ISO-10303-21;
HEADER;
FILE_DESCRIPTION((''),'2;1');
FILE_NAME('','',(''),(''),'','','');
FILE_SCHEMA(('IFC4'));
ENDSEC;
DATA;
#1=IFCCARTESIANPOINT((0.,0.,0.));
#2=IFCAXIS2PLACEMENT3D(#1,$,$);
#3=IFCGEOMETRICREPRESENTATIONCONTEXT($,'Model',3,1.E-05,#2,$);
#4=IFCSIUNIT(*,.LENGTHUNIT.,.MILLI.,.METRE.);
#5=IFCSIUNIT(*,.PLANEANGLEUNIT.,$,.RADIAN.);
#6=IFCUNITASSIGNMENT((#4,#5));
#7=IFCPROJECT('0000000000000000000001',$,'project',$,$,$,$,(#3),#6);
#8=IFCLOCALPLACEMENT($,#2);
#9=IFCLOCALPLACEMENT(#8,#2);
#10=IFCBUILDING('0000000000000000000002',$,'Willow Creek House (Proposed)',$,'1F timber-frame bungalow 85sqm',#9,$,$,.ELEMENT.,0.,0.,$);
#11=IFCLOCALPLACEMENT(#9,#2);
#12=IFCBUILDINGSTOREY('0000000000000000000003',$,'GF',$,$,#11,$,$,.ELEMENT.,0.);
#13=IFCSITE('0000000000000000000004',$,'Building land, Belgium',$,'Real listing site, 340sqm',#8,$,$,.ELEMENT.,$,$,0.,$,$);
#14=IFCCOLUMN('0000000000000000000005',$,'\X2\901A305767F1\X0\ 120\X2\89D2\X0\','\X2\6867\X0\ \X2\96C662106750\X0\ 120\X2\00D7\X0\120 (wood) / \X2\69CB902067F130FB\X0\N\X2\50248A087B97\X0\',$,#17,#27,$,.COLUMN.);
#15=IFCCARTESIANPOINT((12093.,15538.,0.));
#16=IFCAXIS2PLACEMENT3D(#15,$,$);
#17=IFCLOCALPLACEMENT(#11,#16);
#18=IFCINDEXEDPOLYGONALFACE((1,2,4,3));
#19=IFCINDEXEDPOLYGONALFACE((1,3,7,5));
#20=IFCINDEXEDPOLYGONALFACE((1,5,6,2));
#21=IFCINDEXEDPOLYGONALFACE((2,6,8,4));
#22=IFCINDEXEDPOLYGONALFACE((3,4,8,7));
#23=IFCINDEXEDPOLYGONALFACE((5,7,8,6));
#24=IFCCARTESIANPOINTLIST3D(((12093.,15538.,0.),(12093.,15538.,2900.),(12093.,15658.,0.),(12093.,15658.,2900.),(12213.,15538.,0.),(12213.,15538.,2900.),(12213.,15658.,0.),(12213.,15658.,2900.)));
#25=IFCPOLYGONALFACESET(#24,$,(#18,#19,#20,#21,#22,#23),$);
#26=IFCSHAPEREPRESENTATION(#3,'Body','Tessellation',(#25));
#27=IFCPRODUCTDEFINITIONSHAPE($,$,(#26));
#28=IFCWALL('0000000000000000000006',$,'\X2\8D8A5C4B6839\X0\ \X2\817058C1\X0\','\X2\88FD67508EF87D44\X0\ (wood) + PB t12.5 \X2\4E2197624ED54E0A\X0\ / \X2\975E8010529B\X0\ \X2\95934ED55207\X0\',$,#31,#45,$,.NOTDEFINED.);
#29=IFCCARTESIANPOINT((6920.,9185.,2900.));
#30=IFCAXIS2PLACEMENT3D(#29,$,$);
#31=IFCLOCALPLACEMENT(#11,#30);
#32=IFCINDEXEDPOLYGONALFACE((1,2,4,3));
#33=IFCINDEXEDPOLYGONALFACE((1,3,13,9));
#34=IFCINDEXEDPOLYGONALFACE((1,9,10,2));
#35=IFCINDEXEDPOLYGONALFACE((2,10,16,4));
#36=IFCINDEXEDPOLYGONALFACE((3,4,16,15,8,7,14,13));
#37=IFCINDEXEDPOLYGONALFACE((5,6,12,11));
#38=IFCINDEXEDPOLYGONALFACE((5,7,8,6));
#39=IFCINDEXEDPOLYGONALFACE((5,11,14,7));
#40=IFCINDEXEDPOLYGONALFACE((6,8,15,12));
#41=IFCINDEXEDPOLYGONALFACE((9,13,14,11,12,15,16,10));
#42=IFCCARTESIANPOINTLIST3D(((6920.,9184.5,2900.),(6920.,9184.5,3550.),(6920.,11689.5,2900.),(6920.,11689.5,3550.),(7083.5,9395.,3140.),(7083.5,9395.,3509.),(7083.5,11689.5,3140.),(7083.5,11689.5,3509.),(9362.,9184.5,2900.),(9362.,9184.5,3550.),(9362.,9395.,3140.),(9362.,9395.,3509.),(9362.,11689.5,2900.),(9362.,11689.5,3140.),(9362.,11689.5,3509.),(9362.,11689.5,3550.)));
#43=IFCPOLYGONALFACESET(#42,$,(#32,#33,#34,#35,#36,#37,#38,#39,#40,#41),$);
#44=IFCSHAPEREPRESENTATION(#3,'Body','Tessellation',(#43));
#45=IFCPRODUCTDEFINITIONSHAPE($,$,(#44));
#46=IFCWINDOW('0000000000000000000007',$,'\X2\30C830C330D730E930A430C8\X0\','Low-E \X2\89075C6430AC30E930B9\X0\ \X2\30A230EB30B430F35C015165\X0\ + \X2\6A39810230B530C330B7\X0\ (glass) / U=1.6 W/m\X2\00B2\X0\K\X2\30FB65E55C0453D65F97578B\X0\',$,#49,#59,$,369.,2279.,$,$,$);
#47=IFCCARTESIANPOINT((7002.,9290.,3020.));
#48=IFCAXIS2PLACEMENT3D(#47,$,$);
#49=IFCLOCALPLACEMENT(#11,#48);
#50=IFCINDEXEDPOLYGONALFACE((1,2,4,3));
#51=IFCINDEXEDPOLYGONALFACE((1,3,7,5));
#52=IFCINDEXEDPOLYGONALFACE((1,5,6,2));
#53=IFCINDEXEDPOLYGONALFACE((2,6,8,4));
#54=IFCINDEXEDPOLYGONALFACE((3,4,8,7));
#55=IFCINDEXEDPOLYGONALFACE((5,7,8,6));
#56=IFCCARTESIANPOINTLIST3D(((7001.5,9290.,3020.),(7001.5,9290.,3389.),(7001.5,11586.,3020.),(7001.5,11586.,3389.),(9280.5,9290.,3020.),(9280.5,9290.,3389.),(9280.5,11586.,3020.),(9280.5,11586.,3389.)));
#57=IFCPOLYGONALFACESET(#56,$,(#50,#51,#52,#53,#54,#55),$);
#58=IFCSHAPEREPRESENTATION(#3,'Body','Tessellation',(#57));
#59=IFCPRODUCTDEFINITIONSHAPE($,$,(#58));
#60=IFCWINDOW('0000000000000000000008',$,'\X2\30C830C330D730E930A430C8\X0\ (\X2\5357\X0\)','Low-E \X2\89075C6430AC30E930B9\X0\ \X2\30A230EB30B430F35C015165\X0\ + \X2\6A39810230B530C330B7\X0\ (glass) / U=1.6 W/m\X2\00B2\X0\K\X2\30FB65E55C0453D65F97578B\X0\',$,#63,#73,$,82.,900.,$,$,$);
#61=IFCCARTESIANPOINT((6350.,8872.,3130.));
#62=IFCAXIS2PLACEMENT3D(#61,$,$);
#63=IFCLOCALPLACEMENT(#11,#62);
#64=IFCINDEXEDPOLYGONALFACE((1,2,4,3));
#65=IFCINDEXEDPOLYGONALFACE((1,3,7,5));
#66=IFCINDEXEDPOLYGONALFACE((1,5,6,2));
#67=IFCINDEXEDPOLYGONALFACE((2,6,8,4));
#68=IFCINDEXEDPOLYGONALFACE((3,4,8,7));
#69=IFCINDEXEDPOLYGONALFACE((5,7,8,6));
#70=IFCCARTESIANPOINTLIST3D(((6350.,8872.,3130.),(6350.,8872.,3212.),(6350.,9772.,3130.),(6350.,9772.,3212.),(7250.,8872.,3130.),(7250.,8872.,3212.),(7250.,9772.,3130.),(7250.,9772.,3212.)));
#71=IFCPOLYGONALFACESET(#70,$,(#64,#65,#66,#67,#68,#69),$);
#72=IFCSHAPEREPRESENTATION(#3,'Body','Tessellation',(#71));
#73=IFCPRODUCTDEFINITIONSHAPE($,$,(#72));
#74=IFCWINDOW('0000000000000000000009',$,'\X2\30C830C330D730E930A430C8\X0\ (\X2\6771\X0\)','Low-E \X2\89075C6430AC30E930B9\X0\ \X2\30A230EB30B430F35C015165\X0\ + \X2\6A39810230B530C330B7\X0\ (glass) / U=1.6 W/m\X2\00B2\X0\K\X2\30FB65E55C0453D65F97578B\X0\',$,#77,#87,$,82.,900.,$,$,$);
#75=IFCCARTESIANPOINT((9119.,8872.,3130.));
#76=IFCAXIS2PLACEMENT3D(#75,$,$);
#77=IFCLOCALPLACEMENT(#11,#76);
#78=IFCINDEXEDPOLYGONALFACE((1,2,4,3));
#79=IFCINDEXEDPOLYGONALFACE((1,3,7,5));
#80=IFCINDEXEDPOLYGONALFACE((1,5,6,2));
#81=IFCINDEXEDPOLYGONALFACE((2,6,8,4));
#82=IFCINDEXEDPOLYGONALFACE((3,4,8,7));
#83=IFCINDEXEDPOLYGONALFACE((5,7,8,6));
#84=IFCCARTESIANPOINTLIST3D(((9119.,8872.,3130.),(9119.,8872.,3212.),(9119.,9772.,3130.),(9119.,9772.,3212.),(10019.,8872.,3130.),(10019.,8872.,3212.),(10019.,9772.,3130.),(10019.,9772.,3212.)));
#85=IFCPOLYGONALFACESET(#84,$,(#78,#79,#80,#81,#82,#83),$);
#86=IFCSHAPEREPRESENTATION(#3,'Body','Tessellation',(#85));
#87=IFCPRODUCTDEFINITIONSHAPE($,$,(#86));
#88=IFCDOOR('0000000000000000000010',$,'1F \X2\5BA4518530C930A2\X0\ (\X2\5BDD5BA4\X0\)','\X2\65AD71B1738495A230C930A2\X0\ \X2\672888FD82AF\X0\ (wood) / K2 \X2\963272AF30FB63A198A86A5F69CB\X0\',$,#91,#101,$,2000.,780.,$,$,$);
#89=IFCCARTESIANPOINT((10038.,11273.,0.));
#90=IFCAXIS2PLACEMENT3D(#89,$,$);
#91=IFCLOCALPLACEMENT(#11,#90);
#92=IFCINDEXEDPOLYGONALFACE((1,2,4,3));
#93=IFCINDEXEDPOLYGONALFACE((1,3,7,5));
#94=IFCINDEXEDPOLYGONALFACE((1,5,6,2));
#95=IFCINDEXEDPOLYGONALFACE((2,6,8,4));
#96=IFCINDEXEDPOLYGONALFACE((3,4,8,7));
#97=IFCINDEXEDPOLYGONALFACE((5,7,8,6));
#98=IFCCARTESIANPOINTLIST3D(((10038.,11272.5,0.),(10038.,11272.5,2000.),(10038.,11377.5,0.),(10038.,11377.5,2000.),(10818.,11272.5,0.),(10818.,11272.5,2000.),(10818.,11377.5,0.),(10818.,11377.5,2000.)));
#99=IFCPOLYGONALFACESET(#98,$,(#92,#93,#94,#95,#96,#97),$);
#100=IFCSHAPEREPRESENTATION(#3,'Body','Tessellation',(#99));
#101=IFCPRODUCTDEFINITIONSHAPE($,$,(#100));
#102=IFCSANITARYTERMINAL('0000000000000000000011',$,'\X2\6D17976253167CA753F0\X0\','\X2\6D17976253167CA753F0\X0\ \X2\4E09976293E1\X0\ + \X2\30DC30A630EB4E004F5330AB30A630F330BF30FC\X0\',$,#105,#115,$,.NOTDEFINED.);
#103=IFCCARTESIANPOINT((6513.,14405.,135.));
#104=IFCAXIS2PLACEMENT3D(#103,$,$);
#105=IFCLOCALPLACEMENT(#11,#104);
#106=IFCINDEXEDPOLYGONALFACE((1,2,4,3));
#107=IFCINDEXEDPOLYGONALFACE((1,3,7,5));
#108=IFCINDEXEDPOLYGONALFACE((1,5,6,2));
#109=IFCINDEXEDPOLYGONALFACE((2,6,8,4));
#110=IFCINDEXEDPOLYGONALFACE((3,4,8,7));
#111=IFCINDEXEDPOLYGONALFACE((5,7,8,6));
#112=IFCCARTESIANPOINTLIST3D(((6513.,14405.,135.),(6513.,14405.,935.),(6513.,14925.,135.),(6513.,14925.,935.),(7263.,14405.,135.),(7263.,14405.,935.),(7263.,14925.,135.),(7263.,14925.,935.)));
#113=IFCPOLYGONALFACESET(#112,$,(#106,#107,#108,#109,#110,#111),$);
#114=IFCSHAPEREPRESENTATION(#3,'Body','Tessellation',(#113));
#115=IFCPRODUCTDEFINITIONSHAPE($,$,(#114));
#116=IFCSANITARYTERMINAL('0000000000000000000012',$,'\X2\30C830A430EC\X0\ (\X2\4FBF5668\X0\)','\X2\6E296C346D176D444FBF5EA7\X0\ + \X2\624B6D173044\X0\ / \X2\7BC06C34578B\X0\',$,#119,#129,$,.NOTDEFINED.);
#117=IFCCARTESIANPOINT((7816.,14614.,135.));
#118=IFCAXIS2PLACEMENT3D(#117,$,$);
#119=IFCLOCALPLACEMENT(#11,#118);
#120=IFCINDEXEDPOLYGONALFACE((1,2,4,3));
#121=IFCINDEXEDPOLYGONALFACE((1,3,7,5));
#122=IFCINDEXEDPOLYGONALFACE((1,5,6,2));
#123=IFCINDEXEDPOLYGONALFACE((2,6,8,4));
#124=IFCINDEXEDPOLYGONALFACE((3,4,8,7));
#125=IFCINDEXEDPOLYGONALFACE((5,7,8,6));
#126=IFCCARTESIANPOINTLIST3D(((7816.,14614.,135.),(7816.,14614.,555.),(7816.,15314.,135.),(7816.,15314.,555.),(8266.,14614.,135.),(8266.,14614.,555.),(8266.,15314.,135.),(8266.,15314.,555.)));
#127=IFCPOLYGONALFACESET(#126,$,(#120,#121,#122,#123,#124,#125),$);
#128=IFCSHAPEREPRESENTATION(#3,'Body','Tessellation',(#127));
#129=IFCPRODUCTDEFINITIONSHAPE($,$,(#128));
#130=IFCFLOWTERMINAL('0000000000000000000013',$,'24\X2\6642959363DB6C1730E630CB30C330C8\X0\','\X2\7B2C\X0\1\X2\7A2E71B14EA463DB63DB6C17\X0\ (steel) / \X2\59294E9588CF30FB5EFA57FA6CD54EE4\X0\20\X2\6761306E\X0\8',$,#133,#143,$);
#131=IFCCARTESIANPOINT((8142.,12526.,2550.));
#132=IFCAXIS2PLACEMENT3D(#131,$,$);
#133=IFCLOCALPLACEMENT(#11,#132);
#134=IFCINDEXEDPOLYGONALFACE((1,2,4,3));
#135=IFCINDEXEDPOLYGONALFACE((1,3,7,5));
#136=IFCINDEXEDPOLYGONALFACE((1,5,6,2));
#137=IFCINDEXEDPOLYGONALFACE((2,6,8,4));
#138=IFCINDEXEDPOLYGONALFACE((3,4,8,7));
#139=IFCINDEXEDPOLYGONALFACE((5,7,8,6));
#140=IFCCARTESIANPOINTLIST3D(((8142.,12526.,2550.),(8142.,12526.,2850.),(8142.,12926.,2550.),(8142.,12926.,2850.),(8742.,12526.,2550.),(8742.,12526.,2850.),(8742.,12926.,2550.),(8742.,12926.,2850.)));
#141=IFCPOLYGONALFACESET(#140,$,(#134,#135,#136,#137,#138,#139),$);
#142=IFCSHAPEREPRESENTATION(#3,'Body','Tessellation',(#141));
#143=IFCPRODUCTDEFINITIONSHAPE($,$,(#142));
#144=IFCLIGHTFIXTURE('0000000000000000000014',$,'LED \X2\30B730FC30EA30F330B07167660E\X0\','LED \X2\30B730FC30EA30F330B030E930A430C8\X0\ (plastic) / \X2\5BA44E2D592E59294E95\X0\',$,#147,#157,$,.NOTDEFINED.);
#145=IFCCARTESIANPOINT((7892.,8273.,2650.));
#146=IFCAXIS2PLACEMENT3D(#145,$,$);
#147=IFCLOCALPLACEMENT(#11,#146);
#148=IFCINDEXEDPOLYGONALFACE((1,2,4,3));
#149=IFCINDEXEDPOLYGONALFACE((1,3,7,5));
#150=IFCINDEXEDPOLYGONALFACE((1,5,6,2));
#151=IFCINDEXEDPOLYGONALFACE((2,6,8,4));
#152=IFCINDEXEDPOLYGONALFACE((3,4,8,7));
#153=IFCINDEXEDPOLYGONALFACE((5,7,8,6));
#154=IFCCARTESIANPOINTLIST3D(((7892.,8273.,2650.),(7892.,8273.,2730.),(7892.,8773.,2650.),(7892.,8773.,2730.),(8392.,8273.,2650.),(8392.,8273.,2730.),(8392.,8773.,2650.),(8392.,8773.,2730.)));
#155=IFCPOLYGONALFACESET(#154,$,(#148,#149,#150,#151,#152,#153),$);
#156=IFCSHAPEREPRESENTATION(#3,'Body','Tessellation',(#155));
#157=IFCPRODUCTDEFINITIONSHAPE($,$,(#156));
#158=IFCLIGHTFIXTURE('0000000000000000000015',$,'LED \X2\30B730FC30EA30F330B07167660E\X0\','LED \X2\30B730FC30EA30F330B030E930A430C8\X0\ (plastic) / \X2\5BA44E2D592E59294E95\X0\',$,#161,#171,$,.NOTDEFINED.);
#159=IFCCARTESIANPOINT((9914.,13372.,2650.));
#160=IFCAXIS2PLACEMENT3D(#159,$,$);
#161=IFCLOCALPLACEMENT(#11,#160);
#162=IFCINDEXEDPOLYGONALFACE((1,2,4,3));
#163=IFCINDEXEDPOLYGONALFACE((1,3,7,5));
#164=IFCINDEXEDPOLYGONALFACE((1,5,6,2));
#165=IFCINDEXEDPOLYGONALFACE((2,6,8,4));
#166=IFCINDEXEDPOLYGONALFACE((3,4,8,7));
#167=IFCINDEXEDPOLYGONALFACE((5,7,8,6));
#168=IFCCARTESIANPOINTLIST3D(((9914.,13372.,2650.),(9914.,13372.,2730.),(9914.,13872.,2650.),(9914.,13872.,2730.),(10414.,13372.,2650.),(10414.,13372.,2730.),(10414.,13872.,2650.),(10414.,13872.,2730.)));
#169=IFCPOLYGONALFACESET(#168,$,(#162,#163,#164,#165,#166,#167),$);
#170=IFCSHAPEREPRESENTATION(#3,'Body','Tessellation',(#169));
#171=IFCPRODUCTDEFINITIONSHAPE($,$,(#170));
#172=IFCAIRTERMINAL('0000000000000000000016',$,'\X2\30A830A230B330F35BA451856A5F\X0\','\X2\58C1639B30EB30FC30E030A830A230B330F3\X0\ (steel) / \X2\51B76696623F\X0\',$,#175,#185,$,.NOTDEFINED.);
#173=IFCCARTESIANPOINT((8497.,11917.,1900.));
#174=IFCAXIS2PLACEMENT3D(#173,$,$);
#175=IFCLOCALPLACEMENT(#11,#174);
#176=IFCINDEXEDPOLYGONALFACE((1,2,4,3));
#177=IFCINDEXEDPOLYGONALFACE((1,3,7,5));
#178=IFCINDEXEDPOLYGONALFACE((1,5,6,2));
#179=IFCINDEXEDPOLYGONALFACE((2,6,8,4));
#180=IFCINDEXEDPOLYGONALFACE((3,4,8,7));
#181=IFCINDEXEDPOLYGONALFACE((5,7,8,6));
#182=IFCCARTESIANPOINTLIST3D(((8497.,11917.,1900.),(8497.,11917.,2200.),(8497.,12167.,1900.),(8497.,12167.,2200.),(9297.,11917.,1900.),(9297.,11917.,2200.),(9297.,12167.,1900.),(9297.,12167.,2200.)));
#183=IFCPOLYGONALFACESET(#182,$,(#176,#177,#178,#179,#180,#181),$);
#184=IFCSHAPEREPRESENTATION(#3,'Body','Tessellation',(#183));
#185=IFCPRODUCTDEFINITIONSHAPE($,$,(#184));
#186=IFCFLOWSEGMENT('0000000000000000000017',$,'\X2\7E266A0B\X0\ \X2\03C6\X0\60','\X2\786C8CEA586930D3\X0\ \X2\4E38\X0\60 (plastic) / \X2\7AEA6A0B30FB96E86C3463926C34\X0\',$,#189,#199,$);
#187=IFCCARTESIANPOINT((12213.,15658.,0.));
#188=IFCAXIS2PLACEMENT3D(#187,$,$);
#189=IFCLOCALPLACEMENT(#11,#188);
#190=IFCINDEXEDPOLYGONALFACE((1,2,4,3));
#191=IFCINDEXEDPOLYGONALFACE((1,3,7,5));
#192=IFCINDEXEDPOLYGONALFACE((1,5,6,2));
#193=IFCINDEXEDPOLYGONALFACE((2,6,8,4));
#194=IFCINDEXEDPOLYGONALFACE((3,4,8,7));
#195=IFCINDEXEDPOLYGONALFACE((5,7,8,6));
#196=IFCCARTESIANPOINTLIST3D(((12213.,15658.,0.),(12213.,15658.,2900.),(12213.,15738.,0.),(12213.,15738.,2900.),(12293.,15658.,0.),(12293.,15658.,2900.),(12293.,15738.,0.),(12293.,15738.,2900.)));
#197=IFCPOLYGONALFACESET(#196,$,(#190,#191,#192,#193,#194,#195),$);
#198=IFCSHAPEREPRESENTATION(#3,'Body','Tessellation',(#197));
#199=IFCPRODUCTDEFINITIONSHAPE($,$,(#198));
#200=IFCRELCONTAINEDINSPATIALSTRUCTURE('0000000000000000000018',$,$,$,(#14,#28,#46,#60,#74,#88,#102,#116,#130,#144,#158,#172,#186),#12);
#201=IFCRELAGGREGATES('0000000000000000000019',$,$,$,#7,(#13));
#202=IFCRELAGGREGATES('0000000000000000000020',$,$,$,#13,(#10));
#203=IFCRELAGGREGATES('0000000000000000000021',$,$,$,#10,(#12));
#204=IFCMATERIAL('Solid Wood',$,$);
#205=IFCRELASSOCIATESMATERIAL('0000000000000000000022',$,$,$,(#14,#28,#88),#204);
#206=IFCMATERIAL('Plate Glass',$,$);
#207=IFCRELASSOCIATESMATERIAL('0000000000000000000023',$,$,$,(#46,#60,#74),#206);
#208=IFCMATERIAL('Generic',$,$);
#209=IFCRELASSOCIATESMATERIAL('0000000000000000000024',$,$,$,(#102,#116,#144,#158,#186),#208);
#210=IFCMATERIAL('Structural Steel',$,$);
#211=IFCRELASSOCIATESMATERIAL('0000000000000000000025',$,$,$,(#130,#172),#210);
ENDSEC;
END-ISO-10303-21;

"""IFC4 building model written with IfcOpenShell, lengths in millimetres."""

from ifc_helpers import new_model, si_unit, frame, frame_2d, origin, place, context, project, spatial, rectangle, extrude, material, element, fill, save


model = new_model("IFC4")

# Units and contexts
model_context = context("Model", 3, precision=1e-05, world=origin())
ifc_project = project(units=[si_unit("LENGTHUNIT", "METRE", prefix="MILLI"), si_unit("PLANEANGLEUNIT", "RADIAN")], contexts=[model_context])

# Site, building, storey
site_placement = place(None, origin())
site = spatial("IfcSite", under=ifc_project, at=site_placement, Name="Building land, Belgium", ObjectType="Real listing site, 340sqm", CompositionType="ELEMENT", RefElevation=0.0)
building_placement = place(site_placement, origin())
building = spatial("IfcBuilding", under=site, at=building_placement, Name="Willow Creek House (Proposed)", ObjectType="1F timber-frame bungalow 85sqm", CompositionType="ELEMENT", ElevationOfRefHeight=0.0, ElevationOfTerrain=0.0)
storey_placement = place(building_placement, origin())
storey = spatial("IfcBuildingStorey", under=building, at=storey_placement, Name="GF", CompositionType="ELEMENT", Elevation=0.0)

# Column
ifc_material_1 = material(Name="Solid Wood")
column_1_placement = place(storey_placement, frame((12093.0, 15538.0, 0.0)))
element("IfcColumn", 1, at=column_1_placement, inside=storey, material=ifc_material_1, Name="通し柱 120角", Description="桧 集成材 120×120 (wood) / 構造柱・N値計算", PredefinedType="COLUMN", context=model_context, shape_type="SweptSolid", body=[
    extrude(rectangle(XDim=120.0, YDim=120.0, at=frame_2d((60.0, 60.0))), frame((12093.0, 15538.0, 0.0)), (0.0, 0.0, 1.0), 2900.0),
])

# Wall, openings, windows
wall_1_placement = place(storey_placement, frame((6920.0, 9185.0, 2900.0)))
wall_1 = element("IfcWall", 2, at=wall_1_placement, inside=storey, material=ifc_material_1, Name="越屋根 腰壁", Description="製材軸組 (wood) + PB t12.5 両面仕上 / 非耐力 間仕切", PredefinedType="NOTDEFINED", context=model_context, shape_type="SweptSolid", body=[
    extrude(rectangle(XDim=2442.0, YDim=2505.0, at=frame_2d((1221.0, 1252.0))), frame((6920.0, 9185.0, 2900.0)), (0.0, 0.0, 1.0), 650.0),
])
opening_1_placement = place(storey_placement, frame((7002.0, 9290.0, 3020.0)))
opening_1 = element("IfcOpeningElement", 3, at=opening_1_placement, cuts=wall_1, PredefinedType="NOTDEFINED", context=model_context, shape_type="SweptSolid", body=[
    extrude(rectangle(XDim=2279.0, YDim=2296.0, at=frame_2d((1139.0, 1148.0))), frame((7002.0, 9290.0, 3020.0)), (0.0, 0.0, 1.0), 369.0),
])
opening_2_placement = place(storey_placement, frame((6350.0, 8872.0, 3130.0)))
opening_2 = element("IfcOpeningElement", 4, at=opening_2_placement, cuts=wall_1, PredefinedType="NOTDEFINED", context=model_context, shape_type="SweptSolid", body=[
    extrude(rectangle(XDim=900.0, YDim=900.0, at=frame_2d((450.0, 450.0))), frame((6350.0, 8872.0, 3130.0)), (0.0, 0.0, 1.0), 82.0),
])
opening_3_placement = place(storey_placement, frame((9119.0, 8872.0, 3130.0)))
opening_3 = element("IfcOpeningElement", 5, at=opening_3_placement, cuts=wall_1, PredefinedType="NOTDEFINED", context=model_context, shape_type="SweptSolid", body=[
    extrude(rectangle(XDim=900.0, YDim=900.0, at=frame_2d((450.0, 450.0))), frame((9119.0, 8872.0, 3130.0)), (0.0, 0.0, 1.0), 82.0),
])
ifc_material_2 = material(Name="Plate Glass")
window_1_placement = place(storey_placement, frame((7002.0, 9290.0, 3020.0)))
window_1 = element("IfcWindow", 6, at=window_1_placement, inside=storey, material=ifc_material_2, Name="トップライト", Description="Low-E 複層ガラス アルゴン封入 + 樹脂サッシ (glass) / U=1.6 W/m²K・日射取得型", OverallHeight=369.0, OverallWidth=2279.0, context=model_context, shape_type="SweptSolid", body=[
    extrude(rectangle(XDim=2279.0, YDim=2296.0, at=frame_2d((1139.0, 1148.0))), frame((7002.0, 9290.0, 3020.0)), (0.0, 0.0, 1.0), 369.0),
])
fill(opening_1, window_1)
window_2_placement = place(storey_placement, frame((6350.0, 8872.0, 3130.0)))
window_2 = element("IfcWindow", 7, at=window_2_placement, inside=storey, material=ifc_material_2, Name="トップライト (南)", Description="Low-E 複層ガラス アルゴン封入 + 樹脂サッシ (glass) / U=1.6 W/m²K・日射取得型", OverallHeight=82.0, OverallWidth=900.0, context=model_context, shape_type="SweptSolid", body=[
    extrude(rectangle(XDim=900.0, YDim=900.0, at=frame_2d((450.0, 450.0))), frame((6350.0, 8872.0, 3130.0)), (0.0, 0.0, 1.0), 82.0),
])
fill(opening_2, window_2)
window_3_placement = place(storey_placement, frame((9119.0, 8872.0, 3130.0)))
window_3 = element("IfcWindow", 8, at=window_3_placement, inside=storey, material=ifc_material_2, Name="トップライト (東)", Description="Low-E 複層ガラス アルゴン封入 + 樹脂サッシ (glass) / U=1.6 W/m²K・日射取得型", OverallHeight=82.0, OverallWidth=900.0, context=model_context, shape_type="SweptSolid", body=[
    extrude(rectangle(XDim=900.0, YDim=900.0, at=frame_2d((450.0, 450.0))), frame((9119.0, 8872.0, 3130.0)), (0.0, 0.0, 1.0), 82.0),
])
fill(opening_3, window_3)

# Door
door_placement = place(storey_placement, frame((10038.0, 11273.0, 0.0)))
element("IfcDoor", 9, at=door_placement, inside=storey, material=ifc_material_1, Name="1F 室内ドア (寝室)", Description="断熱玄関ドア 木製芯 (wood) / K2 防犯・採風機構", OverallHeight=2000.0, OverallWidth=780.0, context=model_context, shape_type="SweptSolid", body=[
    extrude(rectangle(XDim=780.0, YDim=105.0, at=frame_2d((390.0, 52.0))), frame((10038.0, 11273.0, 0.0)), (0.0, 0.0, 1.0), 2000.0),
])

# Shared definitions
ifc_material_3 = material(Name="Structural Steel")

# Sanitary terminals
ifc_material_4 = material(Name="Generic")
sanitary_terminal_1_placement = place(storey_placement, frame((6513.0, 14405.0, 135.0)))
element("IfcSanitaryTerminal", 10, at=sanitary_terminal_1_placement, inside=storey, material=ifc_material_4, Name="洗面化粧台", Description="洗面化粧台 三面鏡 + ボウル一体カウンター", PredefinedType="NOTDEFINED", context=model_context, shape_type="SweptSolid", body=[
    extrude(rectangle(XDim=750.0, YDim=520.0, at=frame_2d((375.0, 260.0))), frame((6513.0, 14405.0, 135.0)), (0.0, 0.0, 1.0), 800.0),
])
sanitary_terminal_2_placement = place(storey_placement, frame((7816.0, 14614.0, 135.0)))
element("IfcSanitaryTerminal", 11, at=sanitary_terminal_2_placement, inside=storey, material=ifc_material_4, Name="トイレ (便器)", Description="温水洗浄便座 + 手洗い / 節水型", PredefinedType="NOTDEFINED", context=model_context, shape_type="SweptSolid", body=[
    extrude(rectangle(XDim=450.0, YDim=700.0, at=frame_2d((225.0, 350.0))), frame((7816.0, 14614.0, 135.0)), (0.0, 0.0, 1.0), 420.0),
])

# Flow terminal
flow_terminal_placement = place(storey_placement, frame((8142.0, 12526.0, 2550.0)))
element("IfcFlowTerminal", 12, at=flow_terminal_placement, inside=storey, material=ifc_material_3, Name="24時間換気ユニット", Description="第1種熱交換換気 (steel) / 天井裏・建基法令20条の8", context=model_context, shape_type="SweptSolid", body=[
    extrude(rectangle(XDim=600.0, YDim=400.0, at=frame_2d((300.0, 200.0))), frame((8142.0, 12526.0, 2550.0)), (0.0, 0.0, 1.0), 300.0),
])

# Light fixtures
light_fixture_1_placement = place(storey_placement, frame((7892.0, 8273.0, 2650.0)))
element("IfcLightFixture", 13, at=light_fixture_1_placement, inside=storey, material=ifc_material_4, Name="LED シーリング照明", Description="LED シーリングライト (plastic) / 室中央天井", PredefinedType="NOTDEFINED", context=model_context, shape_type="SweptSolid", body=[
    extrude(rectangle(XDim=500.0, YDim=500.0, at=frame_2d((250.0, 250.0))), frame((7892.0, 8273.0, 2650.0)), (0.0, 0.0, 1.0), 80.0),
])
light_fixture_2_placement = place(storey_placement, frame((9914.0, 13372.0, 2650.0)))
element("IfcLightFixture", 14, at=light_fixture_2_placement, inside=storey, material=ifc_material_4, Name="LED シーリング照明", Description="LED シーリングライト (plastic) / 室中央天井", PredefinedType="NOTDEFINED", context=model_context, shape_type="SweptSolid", body=[
    extrude(rectangle(XDim=500.0, YDim=500.0, at=frame_2d((250.0, 250.0))), frame((9914.0, 13372.0, 2650.0)), (0.0, 0.0, 1.0), 80.0),
])

# Air terminal
air_terminal_placement = place(storey_placement, frame((8497.0, 11917.0, 1900.0)))
element("IfcAirTerminal", 15, at=air_terminal_placement, inside=storey, material=ifc_material_3, Name="エアコン室内機", Description="壁掛ルームエアコン (steel) / 冷暖房", PredefinedType="NOTDEFINED", context=model_context, shape_type="SweptSolid", body=[
    extrude(rectangle(XDim=800.0, YDim=250.0, at=frame_2d((400.0, 125.0))), frame((8497.0, 11917.0, 1900.0)), (0.0, 0.0, 1.0), 300.0),
])

# Flow segment
flow_segment_placement = place(storey_placement, frame((12213.0, 15658.0, 0.0)))
element("IfcFlowSegment", 16, at=flow_segment_placement, inside=storey, material=ifc_material_4, Name="縦樋 φ60", Description="硬質塩ビ 丸60 (plastic) / 竪樋・雨水排水", context=model_context, shape_type="SweptSolid", body=[
    extrude(rectangle(XDim=80.0, YDim=80.0, at=frame_2d((40.0, 40.0))), frame((12213.0, 15658.0, 0.0)), (0.0, 0.0, 1.0), 2900.0),
])

save(model, "model.ifc")
